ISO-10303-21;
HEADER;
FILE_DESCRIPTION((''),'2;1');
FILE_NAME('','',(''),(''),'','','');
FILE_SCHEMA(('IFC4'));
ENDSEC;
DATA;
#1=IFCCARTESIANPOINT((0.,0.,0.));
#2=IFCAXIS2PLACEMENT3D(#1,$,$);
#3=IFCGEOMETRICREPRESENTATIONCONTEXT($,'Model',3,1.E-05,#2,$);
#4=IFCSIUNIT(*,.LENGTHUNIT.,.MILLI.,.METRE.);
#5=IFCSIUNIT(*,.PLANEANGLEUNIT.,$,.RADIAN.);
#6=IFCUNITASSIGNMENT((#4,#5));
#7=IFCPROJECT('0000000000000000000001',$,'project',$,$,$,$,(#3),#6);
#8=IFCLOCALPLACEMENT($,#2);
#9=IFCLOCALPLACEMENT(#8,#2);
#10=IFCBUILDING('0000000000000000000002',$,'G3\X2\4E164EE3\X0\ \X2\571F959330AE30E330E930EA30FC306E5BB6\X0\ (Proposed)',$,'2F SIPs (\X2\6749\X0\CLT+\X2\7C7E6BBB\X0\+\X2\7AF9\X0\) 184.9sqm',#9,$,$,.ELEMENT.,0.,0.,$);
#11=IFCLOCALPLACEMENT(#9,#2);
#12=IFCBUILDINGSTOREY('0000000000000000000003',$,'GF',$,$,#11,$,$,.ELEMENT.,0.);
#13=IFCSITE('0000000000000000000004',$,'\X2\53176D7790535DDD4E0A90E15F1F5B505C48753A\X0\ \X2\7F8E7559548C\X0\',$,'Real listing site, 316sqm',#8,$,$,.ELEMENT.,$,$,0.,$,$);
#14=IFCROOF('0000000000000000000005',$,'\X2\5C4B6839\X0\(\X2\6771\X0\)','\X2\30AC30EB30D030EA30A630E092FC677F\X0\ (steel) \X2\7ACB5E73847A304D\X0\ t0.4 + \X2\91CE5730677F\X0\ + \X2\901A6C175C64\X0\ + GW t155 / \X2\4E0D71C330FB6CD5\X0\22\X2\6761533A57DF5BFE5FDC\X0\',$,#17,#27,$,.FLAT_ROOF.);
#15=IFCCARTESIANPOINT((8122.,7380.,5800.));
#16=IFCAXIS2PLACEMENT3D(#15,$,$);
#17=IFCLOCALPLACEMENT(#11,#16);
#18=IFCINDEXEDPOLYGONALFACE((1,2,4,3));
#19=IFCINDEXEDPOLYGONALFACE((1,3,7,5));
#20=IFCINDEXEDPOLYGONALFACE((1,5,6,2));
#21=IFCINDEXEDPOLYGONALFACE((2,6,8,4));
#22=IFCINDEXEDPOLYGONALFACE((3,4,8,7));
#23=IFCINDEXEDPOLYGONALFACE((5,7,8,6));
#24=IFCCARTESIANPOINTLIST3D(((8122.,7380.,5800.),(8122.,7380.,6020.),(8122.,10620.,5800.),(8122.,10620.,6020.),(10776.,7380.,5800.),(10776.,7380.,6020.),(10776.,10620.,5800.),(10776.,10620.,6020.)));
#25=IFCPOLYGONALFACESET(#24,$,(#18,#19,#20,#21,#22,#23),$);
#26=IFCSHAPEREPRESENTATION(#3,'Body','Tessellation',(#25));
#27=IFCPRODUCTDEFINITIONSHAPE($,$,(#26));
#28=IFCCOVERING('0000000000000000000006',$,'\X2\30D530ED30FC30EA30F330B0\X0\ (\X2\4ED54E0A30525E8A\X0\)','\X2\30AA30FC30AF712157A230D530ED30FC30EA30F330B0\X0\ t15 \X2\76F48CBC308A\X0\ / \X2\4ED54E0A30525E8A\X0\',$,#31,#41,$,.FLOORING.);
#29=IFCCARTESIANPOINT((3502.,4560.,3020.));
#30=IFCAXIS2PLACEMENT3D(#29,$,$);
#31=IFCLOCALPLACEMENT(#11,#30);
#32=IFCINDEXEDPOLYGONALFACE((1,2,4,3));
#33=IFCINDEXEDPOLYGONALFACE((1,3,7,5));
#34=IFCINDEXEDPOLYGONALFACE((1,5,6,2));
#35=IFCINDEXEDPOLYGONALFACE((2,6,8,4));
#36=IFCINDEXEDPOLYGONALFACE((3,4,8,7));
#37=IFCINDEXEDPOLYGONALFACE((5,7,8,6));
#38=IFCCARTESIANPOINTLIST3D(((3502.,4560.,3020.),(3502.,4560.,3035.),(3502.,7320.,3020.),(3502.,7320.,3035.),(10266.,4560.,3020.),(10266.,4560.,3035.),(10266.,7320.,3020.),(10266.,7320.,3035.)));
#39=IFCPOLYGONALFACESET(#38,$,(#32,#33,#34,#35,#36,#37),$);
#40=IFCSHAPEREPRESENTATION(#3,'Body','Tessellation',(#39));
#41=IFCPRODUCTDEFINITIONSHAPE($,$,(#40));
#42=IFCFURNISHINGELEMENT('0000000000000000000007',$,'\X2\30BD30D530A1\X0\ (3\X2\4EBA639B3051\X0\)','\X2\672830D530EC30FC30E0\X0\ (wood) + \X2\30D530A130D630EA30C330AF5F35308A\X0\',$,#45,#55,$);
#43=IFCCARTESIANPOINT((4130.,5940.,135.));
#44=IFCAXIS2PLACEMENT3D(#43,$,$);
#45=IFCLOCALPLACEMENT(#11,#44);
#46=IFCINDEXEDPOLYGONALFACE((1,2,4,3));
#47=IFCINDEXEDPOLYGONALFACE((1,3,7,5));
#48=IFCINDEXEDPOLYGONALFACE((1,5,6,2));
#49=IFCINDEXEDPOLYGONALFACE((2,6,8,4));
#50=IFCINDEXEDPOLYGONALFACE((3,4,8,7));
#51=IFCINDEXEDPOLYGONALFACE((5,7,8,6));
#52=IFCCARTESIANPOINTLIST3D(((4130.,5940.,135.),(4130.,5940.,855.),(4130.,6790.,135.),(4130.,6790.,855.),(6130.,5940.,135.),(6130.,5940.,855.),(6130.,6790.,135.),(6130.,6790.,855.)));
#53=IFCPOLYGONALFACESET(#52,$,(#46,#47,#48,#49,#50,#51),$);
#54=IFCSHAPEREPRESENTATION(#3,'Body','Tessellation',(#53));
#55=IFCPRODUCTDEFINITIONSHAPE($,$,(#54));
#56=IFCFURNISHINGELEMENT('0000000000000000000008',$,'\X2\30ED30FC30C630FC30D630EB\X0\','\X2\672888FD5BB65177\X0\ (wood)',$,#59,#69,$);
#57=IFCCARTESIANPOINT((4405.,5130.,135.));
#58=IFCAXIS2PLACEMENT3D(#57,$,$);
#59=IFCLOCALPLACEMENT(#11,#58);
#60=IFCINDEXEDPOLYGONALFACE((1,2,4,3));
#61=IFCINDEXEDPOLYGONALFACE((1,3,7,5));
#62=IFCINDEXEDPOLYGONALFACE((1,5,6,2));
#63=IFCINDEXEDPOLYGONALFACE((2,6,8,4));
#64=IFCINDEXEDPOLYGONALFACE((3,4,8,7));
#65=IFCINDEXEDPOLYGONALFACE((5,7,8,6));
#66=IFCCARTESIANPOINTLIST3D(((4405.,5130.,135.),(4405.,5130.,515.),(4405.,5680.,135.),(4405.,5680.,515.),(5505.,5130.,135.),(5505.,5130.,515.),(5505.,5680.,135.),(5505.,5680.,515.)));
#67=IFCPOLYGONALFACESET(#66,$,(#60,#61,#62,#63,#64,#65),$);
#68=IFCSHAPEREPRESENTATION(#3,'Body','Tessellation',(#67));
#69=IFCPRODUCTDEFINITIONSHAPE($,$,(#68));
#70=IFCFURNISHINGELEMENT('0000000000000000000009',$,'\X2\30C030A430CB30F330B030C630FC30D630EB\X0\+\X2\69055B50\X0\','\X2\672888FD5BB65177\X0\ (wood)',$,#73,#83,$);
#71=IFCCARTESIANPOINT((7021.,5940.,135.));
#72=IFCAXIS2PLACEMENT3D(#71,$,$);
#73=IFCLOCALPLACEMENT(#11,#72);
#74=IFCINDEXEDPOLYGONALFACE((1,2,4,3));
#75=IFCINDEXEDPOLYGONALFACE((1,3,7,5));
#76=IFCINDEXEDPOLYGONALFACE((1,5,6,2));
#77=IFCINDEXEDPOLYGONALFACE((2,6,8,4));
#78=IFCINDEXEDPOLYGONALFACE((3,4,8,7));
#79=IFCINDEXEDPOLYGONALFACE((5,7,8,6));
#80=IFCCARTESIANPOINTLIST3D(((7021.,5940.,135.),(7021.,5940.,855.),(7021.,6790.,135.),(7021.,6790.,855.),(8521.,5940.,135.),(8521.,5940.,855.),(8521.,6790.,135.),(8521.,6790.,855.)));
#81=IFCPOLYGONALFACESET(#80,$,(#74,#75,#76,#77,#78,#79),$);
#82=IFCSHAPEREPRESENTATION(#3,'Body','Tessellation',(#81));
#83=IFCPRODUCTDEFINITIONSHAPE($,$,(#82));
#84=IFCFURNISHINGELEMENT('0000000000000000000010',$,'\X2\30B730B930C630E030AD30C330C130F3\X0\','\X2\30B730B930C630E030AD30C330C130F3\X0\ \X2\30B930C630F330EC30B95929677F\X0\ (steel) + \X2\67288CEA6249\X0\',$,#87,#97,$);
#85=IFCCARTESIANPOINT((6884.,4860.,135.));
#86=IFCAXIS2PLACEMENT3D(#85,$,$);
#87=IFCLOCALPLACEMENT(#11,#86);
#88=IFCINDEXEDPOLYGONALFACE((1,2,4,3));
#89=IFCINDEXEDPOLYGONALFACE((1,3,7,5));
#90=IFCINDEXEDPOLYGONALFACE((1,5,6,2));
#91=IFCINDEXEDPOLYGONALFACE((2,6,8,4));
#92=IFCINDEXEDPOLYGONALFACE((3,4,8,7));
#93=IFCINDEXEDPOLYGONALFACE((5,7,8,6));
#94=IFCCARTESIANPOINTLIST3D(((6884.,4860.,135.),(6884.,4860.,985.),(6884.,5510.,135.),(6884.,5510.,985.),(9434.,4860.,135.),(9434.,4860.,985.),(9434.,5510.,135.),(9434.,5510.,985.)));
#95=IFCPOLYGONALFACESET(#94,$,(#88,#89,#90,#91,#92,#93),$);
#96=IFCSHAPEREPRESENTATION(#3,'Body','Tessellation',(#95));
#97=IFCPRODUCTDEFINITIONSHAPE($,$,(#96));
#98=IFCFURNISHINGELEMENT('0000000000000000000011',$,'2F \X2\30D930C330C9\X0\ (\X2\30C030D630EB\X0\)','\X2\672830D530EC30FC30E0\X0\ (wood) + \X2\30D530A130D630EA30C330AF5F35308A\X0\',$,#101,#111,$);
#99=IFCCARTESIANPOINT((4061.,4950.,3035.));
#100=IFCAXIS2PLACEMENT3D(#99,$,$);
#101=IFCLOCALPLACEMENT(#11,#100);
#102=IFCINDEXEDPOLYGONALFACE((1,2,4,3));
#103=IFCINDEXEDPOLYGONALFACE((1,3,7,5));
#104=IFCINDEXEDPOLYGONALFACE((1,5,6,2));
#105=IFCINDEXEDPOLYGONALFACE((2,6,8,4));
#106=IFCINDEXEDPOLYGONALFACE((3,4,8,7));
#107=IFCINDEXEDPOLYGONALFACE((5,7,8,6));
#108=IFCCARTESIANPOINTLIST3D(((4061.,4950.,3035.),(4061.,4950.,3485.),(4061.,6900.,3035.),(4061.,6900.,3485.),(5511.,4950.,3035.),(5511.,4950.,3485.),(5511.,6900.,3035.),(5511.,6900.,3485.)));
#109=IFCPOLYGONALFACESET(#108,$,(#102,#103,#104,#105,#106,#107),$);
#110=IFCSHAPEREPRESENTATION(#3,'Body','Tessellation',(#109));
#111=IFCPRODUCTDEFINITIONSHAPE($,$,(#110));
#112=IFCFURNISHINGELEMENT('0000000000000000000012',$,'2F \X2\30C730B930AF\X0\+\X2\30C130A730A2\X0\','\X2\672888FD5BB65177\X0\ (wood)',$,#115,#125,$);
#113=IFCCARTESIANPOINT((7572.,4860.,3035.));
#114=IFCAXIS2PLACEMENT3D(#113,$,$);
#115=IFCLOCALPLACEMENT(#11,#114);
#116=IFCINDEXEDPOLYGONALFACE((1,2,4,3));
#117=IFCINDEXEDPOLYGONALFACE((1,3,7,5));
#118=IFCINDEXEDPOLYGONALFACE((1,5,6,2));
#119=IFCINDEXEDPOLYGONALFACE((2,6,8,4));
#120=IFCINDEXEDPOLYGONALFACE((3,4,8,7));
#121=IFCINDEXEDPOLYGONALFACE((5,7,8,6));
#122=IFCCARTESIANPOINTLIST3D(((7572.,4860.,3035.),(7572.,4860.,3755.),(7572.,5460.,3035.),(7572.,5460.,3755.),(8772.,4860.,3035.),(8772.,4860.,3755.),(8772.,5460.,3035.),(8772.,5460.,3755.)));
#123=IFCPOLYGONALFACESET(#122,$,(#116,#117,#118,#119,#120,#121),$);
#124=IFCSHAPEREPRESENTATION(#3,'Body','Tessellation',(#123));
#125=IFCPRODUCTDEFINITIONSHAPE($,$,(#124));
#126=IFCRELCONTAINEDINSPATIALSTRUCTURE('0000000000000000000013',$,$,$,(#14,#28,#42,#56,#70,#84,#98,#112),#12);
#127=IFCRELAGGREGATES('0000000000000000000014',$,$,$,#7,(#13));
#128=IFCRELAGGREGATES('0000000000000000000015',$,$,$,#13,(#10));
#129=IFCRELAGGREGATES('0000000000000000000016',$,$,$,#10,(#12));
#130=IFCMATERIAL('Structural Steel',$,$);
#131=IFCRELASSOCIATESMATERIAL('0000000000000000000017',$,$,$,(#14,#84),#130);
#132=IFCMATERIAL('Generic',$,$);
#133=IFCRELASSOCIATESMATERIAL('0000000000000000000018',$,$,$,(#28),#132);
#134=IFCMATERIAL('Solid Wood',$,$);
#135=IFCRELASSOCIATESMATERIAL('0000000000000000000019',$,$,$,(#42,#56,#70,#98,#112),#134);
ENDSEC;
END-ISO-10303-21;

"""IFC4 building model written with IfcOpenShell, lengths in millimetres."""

from ifc_helpers import new_model, si_unit, frame, frame_2d, origin, place, context, project, spatial, rectangle, extrude, material, element, save


model = new_model("IFC4")

# Units and contexts
model_context = context("Model", 3, precision=1e-05, world=origin())
ifc_project = project(units=[si_unit("LENGTHUNIT", "METRE", prefix="MILLI"), si_unit("PLANEANGLEUNIT", "RADIAN")], contexts=[model_context])

# Site, building, storey
site_placement = place(None, origin())
site = spatial("IfcSite", under=ifc_project, at=site_placement, Name="北海道川上郡弟子屈町 美留和", ObjectType="Real listing site, 316sqm", CompositionType="ELEMENT", RefElevation=0.0)
building_placement = place(site_placement, origin())
building = spatial("IfcBuilding", under=site, at=building_placement, Name="G3世代 土間ギャラリーの家 (Proposed)", ObjectType="2F SIPs (杉CLT+籾殻+竹) 184.9sqm", CompositionType="ELEMENT", ElevationOfRefHeight=0.0, ElevationOfTerrain=0.0)
storey_placement = place(building_placement, origin())
storey = spatial("IfcBuildingStorey", under=building, at=storey_placement, Name="GF", CompositionType="ELEMENT", Elevation=0.0)

# Shared definitions
ifc_material_1 = material(Name="Solid Wood")

# Shared definitions
ifc_material_2 = material(Name="Generic")

# Roof
ifc_material_3 = material(Name="Structural Steel")
roof_placement = place(storey_placement, frame((8122.0, 7380.0, 5800.0)))
element("IfcRoof", 1, at=roof_placement, inside=storey, material=ifc_material_3, Name="屋根(東)", Description="ガルバリウム鋼板 (steel) 立平葺き t0.4 + 野地板 + 通気層 + GW t155 / 不燃・法22条区域対応", PredefinedType="FLAT_ROOF", context=model_context, shape_type="SweptSolid", body=[
    extrude(rectangle(XDim=2654.0, YDim=3240.0, at=frame_2d((1327.0, 1620.0))), frame((8122.0, 7380.0, 5800.0)), (0.0, 0.0, 1.0), 220.0),
])

# Covering
covering_placement = place(storey_placement, frame((3502.0, 4560.0, 3020.0)))
element("IfcCovering", 2, at=covering_placement, inside=storey, material=ifc_material_2, Name="フローリング (仕上げ床)", Description="オーク無垢フローリング t15 直貼り / 仕上げ床", PredefinedType="FLOORING", context=model_context, shape_type="SweptSolid", body=[
    extrude(rectangle(XDim=6764.0, YDim=2760.0, at=frame_2d((3382.0, 1380.0))), frame((3502.0, 4560.0, 3020.0)), (0.0, 0.0, 1.0), 15.0),
])

# Furnishing elements
furnishing_1_placement = place(storey_placement, frame((4130.0, 5940.0, 135.0)))
element("IfcFurnishingElement", 3, at=furnishing_1_placement, inside=storey, material=ifc_material_1, Name="ソファ (3人掛け)", Description="木フレーム (wood) + ファブリック張り", context=model_context, shape_type="SweptSolid", body=[
    extrude(rectangle(XDim=2000.0, YDim=850.0, at=frame_2d((1000.0, 425.0))), frame((4130.0, 5940.0, 135.0)), (0.0, 0.0, 1.0), 720.0),
])
furnishing_2_placement = place(storey_placement, frame((4405.0, 5130.0, 135.0)))
element("IfcFurnishingElement", 4, at=furnishing_2_placement, inside=storey, material=ifc_material_1, Name="ローテーブル", Description="木製家具 (wood)", context=model_context, shape_type="SweptSolid", body=[
    extrude(rectangle(XDim=1100.0, YDim=550.0, at=frame_2d((550.0, 275.0))), frame((4405.0, 5130.0, 135.0)), (0.0, 0.0, 1.0), 380.0),
])
furnishing_3_placement = place(storey_placement, frame((7021.0, 5940.0, 135.0)))
element("IfcFurnishingElement", 5, at=furnishing_3_placement, inside=storey, material=ifc_material_1, Name="ダイニングテーブル+椅子", Description="木製家具 (wood)", context=model_context, shape_type="SweptSolid", body=[
    extrude(rectangle(XDim=1500.0, YDim=850.0, at=frame_2d((750.0, 425.0))), frame((7021.0, 5940.0, 135.0)), (0.0, 0.0, 1.0), 720.0),
])
furnishing_4_placement = place(storey_placement, frame((6884.0, 4860.0, 135.0)))
element("IfcFurnishingElement", 6, at=furnishing_4_placement, inside=storey, material=ifc_material_3, Name="システムキッチン", Description="システムキッチン ステンレス天板 (steel) + 木質扉", context=model_context, shape_type="SweptSolid", body=[
    extrude(rectangle(XDim=2550.0, YDim=650.0, at=frame_2d((1275.0, 325.0))), frame((6884.0, 4860.0, 135.0)), (0.0, 0.0, 1.0), 850.0),
])
furnishing_5_placement = place(storey_placement, frame((4061.0, 4950.0, 3035.0)))
element("IfcFurnishingElement", 7, at=furnishing_5_placement, inside=storey, material=ifc_material_1, Name="2F ベッド (ダブル)", Description="木フレーム (wood) + ファブリック張り", context=model_context, shape_type="SweptSolid", body=[
    extrude(rectangle(XDim=1450.0, YDim=1950.0, at=frame_2d((725.0, 975.0))), frame((4061.0, 4950.0, 3035.0)), (0.0, 0.0, 1.0), 450.0),
])
furnishing_6_placement = place(storey_placement, frame((7572.0, 4860.0, 3035.0)))
element("IfcFurnishingElement", 8, at=furnishing_6_placement, inside=storey, material=ifc_material_1, Name="2F デスク+チェア", Description="木製家具 (wood)", context=model_context, shape_type="SweptSolid", body=[
    extrude(rectangle(XDim=1200.0, YDim=600.0, at=frame_2d((600.0, 300.0))), frame((7572.0, 4860.0, 3035.0)), (0.0, 0.0, 1.0), 720.0),
])

save(model, "model.ifc")
